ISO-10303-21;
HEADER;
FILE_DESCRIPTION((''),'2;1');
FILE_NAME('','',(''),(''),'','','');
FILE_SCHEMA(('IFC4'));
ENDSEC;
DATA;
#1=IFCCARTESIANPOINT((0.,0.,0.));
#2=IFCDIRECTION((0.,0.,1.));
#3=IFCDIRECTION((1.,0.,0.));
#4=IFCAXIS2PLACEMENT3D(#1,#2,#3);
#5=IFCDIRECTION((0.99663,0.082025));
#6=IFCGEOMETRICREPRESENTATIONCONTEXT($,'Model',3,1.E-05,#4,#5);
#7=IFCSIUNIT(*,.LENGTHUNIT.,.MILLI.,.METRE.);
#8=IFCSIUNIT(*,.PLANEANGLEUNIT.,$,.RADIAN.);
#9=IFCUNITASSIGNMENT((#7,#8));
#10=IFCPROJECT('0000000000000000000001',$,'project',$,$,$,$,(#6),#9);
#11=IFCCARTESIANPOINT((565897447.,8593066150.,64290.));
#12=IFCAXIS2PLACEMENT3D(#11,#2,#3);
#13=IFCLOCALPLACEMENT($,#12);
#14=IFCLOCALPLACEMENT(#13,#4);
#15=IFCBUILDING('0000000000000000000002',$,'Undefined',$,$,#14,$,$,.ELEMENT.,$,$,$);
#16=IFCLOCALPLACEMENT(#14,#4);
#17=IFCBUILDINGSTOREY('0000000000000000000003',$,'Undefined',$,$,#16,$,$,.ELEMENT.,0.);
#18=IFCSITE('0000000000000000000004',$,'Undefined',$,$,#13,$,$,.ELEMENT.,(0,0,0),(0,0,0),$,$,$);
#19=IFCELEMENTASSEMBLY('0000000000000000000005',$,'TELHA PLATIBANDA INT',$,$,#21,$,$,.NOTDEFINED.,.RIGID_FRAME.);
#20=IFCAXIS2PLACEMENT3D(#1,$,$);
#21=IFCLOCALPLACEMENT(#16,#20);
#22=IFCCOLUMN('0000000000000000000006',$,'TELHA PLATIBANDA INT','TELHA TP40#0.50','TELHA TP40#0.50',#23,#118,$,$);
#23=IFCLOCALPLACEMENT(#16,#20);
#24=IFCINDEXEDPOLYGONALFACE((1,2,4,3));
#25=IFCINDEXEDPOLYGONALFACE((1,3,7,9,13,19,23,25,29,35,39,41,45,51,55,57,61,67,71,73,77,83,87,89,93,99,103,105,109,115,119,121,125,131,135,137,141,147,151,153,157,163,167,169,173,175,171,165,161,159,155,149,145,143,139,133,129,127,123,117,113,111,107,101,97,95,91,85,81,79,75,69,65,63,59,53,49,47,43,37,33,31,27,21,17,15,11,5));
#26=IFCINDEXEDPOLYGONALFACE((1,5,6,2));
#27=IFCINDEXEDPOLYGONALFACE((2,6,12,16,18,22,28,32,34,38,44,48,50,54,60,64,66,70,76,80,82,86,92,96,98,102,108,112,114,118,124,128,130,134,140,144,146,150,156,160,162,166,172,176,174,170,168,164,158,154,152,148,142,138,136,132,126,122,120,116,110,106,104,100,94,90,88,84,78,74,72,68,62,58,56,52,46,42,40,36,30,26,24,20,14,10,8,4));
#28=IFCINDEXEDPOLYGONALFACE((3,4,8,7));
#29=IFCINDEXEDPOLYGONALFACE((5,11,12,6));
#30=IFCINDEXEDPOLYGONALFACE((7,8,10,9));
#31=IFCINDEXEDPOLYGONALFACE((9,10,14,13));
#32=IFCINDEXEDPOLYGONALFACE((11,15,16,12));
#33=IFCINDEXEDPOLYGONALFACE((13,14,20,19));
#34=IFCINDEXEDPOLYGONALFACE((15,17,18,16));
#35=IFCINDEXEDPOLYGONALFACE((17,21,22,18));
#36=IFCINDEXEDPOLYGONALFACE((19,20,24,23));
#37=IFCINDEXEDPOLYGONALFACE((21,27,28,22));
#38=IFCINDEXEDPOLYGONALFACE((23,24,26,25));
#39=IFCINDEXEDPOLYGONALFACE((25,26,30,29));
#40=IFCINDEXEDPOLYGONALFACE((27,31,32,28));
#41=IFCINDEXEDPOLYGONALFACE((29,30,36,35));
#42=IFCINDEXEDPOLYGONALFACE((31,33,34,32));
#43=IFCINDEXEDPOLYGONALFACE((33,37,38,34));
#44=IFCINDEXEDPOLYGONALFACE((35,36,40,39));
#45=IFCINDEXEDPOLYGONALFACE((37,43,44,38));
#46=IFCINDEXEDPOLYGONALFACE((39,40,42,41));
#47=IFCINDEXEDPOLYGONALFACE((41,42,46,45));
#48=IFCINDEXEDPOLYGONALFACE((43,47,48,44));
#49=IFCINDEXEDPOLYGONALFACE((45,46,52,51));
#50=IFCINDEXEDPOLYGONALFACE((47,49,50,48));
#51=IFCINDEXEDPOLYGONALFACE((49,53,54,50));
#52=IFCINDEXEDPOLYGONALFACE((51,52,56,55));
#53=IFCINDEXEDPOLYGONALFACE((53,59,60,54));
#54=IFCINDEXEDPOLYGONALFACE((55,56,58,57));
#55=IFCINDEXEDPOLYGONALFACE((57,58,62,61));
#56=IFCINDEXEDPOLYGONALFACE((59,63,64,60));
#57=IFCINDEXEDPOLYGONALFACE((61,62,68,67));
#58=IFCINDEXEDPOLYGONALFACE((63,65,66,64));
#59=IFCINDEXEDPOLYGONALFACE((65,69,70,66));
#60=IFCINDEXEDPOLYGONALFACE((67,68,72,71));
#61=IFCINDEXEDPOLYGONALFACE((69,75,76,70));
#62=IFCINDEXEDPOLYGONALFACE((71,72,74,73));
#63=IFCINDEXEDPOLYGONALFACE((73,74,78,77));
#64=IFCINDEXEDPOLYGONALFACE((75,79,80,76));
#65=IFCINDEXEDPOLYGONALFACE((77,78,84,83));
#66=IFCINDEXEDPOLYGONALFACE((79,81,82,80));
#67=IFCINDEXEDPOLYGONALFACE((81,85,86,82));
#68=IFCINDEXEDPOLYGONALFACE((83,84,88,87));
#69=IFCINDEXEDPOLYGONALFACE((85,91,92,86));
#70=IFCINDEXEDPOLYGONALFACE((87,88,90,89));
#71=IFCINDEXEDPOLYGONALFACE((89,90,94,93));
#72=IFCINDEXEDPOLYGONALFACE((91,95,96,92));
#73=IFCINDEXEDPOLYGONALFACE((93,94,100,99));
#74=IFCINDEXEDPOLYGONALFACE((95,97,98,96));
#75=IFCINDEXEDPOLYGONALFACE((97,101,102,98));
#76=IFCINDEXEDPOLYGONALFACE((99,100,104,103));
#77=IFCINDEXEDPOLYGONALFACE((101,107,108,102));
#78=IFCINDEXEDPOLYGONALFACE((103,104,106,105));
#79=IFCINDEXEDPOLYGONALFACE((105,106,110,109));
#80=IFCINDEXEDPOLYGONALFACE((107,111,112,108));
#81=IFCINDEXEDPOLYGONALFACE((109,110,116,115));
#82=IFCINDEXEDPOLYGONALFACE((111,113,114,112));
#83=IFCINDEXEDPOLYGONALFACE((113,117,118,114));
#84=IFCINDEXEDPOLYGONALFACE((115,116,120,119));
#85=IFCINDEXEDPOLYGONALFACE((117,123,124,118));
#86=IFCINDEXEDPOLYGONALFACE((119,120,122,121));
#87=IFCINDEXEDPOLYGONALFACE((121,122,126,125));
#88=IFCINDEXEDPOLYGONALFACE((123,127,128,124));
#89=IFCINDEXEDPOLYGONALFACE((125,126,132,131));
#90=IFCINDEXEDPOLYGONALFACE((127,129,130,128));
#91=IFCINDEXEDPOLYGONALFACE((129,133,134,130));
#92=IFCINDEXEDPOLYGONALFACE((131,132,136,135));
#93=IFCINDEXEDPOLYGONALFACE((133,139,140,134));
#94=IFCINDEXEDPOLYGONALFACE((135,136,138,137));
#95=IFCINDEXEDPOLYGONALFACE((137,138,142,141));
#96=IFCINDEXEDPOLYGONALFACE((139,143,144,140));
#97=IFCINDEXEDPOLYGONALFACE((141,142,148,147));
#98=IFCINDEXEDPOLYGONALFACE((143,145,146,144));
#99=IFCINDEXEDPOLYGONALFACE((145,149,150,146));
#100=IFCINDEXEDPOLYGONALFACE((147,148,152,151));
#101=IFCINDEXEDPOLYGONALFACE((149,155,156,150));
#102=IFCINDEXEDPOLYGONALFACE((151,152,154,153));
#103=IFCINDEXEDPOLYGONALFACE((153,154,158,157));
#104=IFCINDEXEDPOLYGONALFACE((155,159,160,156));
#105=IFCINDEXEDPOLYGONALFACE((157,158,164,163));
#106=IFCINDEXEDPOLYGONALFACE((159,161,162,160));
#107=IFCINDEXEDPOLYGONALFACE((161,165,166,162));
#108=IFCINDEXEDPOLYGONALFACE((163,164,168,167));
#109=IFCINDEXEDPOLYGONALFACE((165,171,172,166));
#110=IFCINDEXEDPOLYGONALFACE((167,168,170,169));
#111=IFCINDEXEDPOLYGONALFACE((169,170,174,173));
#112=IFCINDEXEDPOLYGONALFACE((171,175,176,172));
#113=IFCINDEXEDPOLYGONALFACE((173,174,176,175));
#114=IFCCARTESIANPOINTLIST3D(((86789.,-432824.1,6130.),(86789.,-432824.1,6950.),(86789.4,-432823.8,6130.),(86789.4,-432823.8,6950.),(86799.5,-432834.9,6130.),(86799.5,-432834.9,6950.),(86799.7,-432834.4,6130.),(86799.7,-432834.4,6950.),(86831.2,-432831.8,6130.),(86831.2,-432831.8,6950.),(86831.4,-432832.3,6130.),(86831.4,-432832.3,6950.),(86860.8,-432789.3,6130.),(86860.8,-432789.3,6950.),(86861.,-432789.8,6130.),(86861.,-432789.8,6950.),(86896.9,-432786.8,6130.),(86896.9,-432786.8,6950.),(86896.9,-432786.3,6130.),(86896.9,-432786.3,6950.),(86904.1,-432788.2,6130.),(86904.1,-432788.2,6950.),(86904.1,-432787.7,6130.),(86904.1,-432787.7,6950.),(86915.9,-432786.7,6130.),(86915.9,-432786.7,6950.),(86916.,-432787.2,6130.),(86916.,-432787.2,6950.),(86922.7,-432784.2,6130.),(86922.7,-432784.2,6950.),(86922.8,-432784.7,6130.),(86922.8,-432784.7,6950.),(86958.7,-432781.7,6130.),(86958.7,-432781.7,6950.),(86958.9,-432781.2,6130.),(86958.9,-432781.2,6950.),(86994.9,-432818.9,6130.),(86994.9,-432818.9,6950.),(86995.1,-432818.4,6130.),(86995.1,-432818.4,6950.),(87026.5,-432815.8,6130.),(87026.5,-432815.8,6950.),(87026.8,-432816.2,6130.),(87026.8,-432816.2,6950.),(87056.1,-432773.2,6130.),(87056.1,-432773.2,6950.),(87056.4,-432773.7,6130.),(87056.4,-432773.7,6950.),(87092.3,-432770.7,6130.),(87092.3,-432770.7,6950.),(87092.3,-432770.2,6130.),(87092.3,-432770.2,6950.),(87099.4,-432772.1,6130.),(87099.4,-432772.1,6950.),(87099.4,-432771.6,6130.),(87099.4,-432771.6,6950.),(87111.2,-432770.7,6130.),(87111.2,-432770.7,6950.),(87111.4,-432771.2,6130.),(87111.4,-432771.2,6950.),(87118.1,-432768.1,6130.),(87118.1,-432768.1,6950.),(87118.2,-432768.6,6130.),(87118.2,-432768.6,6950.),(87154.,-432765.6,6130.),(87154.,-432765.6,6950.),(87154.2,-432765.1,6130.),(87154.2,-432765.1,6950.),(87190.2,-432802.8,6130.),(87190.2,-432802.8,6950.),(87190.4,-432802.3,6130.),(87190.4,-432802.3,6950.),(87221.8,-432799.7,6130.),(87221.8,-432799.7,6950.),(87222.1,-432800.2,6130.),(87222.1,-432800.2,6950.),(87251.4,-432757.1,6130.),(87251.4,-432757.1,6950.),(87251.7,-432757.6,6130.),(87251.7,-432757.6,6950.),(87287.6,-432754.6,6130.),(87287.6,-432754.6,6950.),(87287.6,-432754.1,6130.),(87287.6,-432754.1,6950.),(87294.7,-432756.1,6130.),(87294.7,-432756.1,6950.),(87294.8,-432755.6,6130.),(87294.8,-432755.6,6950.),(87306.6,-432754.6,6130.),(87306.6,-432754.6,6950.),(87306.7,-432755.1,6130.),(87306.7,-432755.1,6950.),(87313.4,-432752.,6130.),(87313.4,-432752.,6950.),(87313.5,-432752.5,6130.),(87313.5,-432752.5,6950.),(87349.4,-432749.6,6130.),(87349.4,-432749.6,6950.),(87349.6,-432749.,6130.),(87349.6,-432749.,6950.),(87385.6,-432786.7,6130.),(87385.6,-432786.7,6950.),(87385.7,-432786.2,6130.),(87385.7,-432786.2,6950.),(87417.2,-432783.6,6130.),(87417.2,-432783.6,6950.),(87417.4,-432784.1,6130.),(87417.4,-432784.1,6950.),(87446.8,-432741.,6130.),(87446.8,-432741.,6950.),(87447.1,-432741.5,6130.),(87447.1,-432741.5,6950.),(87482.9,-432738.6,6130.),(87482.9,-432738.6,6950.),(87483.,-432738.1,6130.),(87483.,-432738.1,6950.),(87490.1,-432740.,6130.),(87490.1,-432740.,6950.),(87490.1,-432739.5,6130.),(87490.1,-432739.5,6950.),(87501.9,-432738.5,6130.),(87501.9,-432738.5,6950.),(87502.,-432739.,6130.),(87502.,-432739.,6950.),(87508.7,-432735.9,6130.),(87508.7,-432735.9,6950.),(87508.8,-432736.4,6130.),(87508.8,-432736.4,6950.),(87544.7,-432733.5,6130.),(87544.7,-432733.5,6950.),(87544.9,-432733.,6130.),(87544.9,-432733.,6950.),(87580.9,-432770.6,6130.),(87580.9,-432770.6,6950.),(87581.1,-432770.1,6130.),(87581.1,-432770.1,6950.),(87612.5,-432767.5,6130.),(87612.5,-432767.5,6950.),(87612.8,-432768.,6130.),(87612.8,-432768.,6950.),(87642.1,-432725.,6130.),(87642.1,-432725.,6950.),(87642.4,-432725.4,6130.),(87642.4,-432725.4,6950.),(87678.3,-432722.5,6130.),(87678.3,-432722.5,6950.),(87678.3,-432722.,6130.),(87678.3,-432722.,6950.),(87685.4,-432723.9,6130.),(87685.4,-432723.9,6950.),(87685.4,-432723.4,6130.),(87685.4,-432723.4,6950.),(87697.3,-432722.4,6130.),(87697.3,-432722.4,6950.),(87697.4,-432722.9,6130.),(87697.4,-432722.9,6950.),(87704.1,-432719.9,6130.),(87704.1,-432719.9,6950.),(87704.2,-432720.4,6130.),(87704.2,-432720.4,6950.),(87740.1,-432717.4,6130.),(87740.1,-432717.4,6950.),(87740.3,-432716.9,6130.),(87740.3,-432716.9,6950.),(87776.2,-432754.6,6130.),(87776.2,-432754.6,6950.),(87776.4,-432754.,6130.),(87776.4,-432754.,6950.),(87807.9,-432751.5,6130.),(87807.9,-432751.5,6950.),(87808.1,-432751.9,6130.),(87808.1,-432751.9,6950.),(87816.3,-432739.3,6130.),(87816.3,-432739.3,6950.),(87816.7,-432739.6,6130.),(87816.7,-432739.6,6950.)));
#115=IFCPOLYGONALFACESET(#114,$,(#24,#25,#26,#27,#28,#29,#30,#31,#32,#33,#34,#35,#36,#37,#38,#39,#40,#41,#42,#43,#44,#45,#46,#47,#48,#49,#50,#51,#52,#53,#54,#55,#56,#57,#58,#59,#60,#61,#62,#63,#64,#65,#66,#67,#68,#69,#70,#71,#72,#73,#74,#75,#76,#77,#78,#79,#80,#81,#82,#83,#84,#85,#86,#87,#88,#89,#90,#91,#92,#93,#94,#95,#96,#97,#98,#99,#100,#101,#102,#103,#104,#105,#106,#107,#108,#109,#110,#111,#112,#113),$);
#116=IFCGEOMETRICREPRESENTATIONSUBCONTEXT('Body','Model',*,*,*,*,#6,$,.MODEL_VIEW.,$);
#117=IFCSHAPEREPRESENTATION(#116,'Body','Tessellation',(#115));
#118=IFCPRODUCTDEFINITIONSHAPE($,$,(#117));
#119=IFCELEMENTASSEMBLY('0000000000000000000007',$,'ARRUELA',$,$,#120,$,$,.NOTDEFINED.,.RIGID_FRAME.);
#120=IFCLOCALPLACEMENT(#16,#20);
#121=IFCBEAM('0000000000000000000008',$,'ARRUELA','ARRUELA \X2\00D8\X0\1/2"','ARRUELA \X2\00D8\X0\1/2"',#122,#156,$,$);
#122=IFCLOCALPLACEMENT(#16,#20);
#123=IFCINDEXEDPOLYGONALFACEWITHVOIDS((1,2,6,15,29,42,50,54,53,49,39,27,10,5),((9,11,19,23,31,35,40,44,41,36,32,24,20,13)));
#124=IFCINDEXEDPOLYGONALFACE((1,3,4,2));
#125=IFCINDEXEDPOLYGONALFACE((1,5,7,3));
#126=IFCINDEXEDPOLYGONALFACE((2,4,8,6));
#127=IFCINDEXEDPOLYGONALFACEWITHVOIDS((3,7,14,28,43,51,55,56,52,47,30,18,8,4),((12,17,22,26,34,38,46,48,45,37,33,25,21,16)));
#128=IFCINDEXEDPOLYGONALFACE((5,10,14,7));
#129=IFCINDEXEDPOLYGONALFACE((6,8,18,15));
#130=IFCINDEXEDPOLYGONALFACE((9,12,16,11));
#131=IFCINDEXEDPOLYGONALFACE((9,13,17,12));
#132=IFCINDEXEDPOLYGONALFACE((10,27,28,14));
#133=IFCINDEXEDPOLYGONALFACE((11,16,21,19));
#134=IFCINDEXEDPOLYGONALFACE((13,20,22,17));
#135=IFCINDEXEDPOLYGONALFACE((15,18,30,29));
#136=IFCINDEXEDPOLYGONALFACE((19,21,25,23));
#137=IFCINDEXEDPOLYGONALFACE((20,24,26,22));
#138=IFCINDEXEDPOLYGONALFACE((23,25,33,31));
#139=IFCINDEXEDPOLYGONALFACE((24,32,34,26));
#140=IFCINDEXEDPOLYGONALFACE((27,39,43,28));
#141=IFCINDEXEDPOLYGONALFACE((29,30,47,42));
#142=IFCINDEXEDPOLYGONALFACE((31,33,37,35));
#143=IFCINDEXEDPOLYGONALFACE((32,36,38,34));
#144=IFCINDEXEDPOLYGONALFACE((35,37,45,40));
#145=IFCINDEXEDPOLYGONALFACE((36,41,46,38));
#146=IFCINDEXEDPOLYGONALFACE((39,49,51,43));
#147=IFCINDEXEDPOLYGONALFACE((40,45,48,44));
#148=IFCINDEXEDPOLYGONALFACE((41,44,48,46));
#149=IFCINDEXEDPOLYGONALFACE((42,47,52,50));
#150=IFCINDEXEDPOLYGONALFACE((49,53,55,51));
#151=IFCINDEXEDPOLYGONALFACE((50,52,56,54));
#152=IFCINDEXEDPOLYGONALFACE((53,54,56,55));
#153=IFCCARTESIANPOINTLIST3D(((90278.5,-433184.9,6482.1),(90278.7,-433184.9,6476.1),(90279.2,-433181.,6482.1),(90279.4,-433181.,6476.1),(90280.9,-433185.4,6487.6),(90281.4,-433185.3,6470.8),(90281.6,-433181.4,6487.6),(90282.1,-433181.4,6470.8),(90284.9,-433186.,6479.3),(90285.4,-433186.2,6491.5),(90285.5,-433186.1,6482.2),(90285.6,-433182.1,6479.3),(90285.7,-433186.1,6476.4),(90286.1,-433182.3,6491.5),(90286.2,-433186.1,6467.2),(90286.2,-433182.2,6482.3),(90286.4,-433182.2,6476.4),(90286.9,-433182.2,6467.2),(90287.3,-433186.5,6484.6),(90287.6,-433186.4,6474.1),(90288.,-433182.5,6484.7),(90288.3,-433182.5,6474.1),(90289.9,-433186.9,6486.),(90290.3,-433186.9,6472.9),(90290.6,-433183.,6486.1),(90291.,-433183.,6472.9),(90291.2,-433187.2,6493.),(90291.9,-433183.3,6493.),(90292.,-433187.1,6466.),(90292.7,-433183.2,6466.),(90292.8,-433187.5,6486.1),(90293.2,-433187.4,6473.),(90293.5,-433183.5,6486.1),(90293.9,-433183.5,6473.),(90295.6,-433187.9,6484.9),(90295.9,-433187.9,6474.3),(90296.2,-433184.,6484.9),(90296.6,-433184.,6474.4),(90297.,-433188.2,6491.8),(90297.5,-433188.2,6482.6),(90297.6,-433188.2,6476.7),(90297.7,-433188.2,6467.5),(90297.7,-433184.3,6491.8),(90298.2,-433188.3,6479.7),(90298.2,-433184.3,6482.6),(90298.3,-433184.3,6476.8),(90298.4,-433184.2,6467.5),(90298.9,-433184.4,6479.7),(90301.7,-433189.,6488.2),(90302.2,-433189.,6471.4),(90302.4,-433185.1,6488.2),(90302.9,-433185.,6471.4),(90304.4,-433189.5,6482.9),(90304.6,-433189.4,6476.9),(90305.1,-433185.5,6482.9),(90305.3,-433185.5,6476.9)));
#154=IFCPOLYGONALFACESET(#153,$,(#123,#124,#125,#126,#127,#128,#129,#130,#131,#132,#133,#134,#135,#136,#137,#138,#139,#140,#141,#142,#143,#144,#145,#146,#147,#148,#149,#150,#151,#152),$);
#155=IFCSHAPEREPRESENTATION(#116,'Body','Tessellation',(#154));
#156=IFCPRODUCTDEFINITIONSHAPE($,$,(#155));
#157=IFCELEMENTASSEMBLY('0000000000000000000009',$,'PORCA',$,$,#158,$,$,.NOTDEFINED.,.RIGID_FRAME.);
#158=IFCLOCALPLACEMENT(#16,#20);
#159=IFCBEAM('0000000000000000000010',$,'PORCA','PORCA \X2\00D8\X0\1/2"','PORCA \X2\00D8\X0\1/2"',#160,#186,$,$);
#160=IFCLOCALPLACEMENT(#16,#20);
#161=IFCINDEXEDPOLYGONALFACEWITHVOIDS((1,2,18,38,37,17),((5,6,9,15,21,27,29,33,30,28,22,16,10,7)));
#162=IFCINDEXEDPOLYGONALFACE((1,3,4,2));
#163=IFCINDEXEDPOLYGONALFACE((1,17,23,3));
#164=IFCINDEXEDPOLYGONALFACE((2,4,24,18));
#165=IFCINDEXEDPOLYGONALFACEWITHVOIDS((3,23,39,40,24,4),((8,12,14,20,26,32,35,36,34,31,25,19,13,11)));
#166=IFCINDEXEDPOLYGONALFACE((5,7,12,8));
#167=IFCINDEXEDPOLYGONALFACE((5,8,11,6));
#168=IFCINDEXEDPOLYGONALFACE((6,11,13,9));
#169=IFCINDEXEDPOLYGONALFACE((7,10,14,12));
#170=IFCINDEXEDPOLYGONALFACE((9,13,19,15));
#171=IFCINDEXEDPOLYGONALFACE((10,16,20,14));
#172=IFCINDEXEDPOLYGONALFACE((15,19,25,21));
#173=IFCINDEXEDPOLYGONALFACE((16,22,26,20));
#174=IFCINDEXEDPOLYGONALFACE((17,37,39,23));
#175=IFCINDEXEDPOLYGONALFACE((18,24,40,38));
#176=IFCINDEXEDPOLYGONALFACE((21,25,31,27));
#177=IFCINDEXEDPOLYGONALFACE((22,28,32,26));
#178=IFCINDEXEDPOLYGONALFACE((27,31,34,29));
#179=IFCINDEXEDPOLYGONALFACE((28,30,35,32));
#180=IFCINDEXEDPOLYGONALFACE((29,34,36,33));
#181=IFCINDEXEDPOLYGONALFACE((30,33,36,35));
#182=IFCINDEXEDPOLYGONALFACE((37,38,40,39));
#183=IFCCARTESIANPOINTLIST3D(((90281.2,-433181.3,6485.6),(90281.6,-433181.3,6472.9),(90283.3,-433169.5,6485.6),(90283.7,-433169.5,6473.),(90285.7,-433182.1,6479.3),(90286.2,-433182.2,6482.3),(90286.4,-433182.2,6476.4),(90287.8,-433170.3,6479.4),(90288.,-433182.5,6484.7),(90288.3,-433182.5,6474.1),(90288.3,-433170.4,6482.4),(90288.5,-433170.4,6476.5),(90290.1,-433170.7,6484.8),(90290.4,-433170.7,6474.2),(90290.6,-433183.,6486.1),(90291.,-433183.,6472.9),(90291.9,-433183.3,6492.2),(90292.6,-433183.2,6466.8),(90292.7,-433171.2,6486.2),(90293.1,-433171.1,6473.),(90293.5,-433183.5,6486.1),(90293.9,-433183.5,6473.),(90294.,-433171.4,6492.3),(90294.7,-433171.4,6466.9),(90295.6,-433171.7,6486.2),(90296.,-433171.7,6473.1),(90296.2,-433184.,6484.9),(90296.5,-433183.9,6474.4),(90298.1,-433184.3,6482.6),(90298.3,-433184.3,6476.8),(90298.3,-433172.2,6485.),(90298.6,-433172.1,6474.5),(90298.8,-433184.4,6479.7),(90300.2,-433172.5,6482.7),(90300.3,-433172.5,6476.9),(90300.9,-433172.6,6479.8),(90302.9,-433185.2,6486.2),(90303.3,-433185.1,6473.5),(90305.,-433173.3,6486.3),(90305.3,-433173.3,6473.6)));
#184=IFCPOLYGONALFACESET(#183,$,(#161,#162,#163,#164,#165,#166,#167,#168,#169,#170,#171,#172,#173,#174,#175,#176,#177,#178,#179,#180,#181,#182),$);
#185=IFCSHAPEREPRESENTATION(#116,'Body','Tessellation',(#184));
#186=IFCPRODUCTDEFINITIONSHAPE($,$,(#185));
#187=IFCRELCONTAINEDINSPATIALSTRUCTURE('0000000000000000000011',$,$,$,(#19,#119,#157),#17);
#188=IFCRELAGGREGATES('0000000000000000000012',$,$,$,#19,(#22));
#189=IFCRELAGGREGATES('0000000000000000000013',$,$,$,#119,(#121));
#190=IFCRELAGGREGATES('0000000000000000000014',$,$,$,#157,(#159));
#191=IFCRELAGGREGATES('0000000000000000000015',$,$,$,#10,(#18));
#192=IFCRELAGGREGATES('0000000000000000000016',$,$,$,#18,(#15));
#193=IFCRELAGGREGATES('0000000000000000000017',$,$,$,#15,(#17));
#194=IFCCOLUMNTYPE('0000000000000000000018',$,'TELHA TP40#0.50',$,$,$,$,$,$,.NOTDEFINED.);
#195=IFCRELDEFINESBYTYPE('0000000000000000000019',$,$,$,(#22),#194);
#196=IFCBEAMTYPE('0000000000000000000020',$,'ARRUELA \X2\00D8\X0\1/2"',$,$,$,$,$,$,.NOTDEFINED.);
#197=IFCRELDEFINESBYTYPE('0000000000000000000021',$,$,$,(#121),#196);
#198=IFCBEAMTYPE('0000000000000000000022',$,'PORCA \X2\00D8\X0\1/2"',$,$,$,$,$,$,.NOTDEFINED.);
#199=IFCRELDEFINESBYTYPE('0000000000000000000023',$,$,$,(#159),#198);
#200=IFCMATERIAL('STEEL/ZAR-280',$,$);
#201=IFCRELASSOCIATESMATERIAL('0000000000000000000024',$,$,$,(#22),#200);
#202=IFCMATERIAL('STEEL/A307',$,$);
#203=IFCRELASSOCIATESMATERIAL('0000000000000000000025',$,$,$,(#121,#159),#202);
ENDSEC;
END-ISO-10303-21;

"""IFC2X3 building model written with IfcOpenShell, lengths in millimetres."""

from ifc_helpers import new_model, si_unit, direction, frame, origin_with_axes, place, context, subcontext, project, spatial, polyline, outline, extrude, material, type_object, element, aggregate, save


model = new_model("IFC2X3")

# Units and contexts
model_context = context("Model", 3, precision=1e-05, world=origin_with_axes(), true_north=direction((0.99663, 0.082025)))
body_context = subcontext(model_context, "Body", "Model", "MODEL_VIEW")
ifc_project = project(units=[si_unit("LENGTHUNIT", "METRE", prefix="MILLI"), si_unit("PLANEANGLEUNIT", "RADIAN")], contexts=[model_context])

# Site, building, storey
site_placement = place(None, frame((565897447.0, 8593066150.0, 64290.0), z_axis=(0.0, 0.0, 1.0), x_axis=(1.0, 0.0, 0.0)))
site = spatial("IfcSite", under=ifc_project, at=site_placement, Name="Undefined", CompositionType="ELEMENT", RefLatitude=(0, 0, 0), RefLongitude=(0, 0, 0))
building_placement = place(site_placement, origin_with_axes())
building = spatial("IfcBuilding", under=site, at=building_placement, Name="Undefined", CompositionType="ELEMENT")
storey_placement = place(building_placement, origin_with_axes())
storey = spatial("IfcBuildingStorey", under=building, at=storey_placement, Name="Undefined", CompositionType="ELEMENT", Elevation=0.0)

# Element assembly, column
ifc_material_1 = material(Name="STEEL/ZAR-280")
column_type = type_object("IfcColumnType", Name="TELHA TP40#0.50", PredefinedType="NOTDEFINED")
assembly_1_placement = place(storey_placement, origin_with_axes())
assembly_1 = element("IfcElementAssembly", 1, at=assembly_1_placement, inside=storey, Name="TELHA PLATIBANDA INT", AssemblyPlace="NOTDEFINED", PredefinedType="RIGID_FRAME")
column_1_placement = place(assembly_1_placement, frame((87302.4, -432773.2, 6130.0), z_axis=(0.0, 0.0, 1.0), x_axis=(0.082025, -0.99663, 0.0)))
column_1 = element("IfcColumn", 2, at=column_1_placement, type_object=column_type, material=ifc_material_1, Name="TELHA PLATIBANDA INT", Description="TELHA TP40#0.50", ObjectType="TELHA TP40#0.50", context=body_context, shape_type="SweptSolid", body=[
    extrude(outline(polyline([(440.8, -19.8), (473.8, 20.2), (505.8, 20.2), (515.4, 8.6), (515.0, 8.3), (505.6, 19.8), (474.0, 19.8), (441.0, -20.2), (404.7, -20.2), (397.7, -18.2), (385.9, -18.2), (378.9, -20.2), (342.6, -20.2), (309.6, 19.8), (278.0, 19.8), (245.0, -20.2), (208.7, -20.2), (201.7, -18.2), (189.9, -18.2), (182.9, -20.2), (146.6, -20.2), (113.6, 19.8), (82.0, 19.8), (49.0, -20.2), (12.7, -20.2), (5.7, -18.2), (-6.1, -18.2), (-13.1, -20.2), (-49.4, -20.2), (-82.4, 19.8), (-114.0, 19.8), (-147.0, -20.2), (-183.3, -20.2), (-190.3, -18.2), (-202.1, -18.2), (-209.1, -20.2), (-245.4, -20.2), (-278.4, 19.8), (-310.0, 19.8), (-343.0, -20.2), (-379.3, -20.2), (-386.3, -18.2), (-398.1, -18.2), (-405.1, -20.2), (-441.4, -20.2), (-474.4, 19.8), (-506.0, 19.8), (-515.4, 8.3), (-515.8, 8.6), (-506.2, 20.2), (-474.2, 20.2), (-441.2, -19.8), (-405.2, -19.8), (-398.2, -17.8), (-386.2, -17.8), (-379.2, -19.8), (-343.2, -19.8), (-310.2, 20.2), (-278.2, 20.2), (-245.2, -19.8), (-209.2, -19.8), (-202.2, -17.8), (-190.2, -17.8), (-183.2, -19.8), (-147.2, -19.8), (-114.2, 20.2), (-82.2, 20.2), (-49.2, -19.8), (-13.2, -19.8), (-6.2, -17.8), (5.8, -17.8), (12.8, -19.8), (48.8, -19.8), (81.8, 20.2), (113.8, 20.2), (146.8, -19.8), (182.8, -19.8), (189.8, -17.8), (201.8, -17.8), (208.8, -19.8), (244.8, -19.8), (277.8, 20.2), (309.8, 20.2), (342.8, -19.8), (378.8, -19.8), (385.8, -17.8), (397.8, -17.8), (404.8, -19.8), (440.8, -19.8)])), frame((0.0, 0.0, 820.0), z_axis=(0.0, 0.0, -1.0), x_axis=(0.0, 1.0, 0.0)), (0.0, 0.0, 1.0), 820.0),
])
aggregate(assembly_1, [column_1])

# Element assemblies, beams
assembly_2_placement = place(storey_placement, origin_with_axes())
assembly_2 = element("IfcElementAssembly", 3, at=assembly_2_placement, inside=storey, Name="ARRUELA", AssemblyPlace="NOTDEFINED", PredefinedType="RIGID_FRAME")
ifc_material_2 = material(Name="STEEL/A307")
beam_type_1 = type_object("IfcBeamType", Name="ARRUELA Ø1/2\"", PredefinedType="NOTDEFINED")
beam_1_placement = place(assembly_2_placement, frame((90292.3, -433183.2, 6479.5), z_axis=(0.984501, -0.172962, 0.02901), x_axis=(-0.172812, -0.984925, -0.007591)))
beam_1 = element("IfcBeam", 4, at=beam_1_placement, type_object=beam_type_1, material=ifc_material_2, Name="ARRUELA", Description="ARRUELA Ø1/2\"", ObjectType="ARRUELA Ø1/2\"", context=body_context, shape_type="SweptSolid", body=[
    extrude(outline(polyline([(-8.4, 10.5), (-3.0, 13.2), (3.0, 13.2), (8.4, 10.5), (12.2, 5.9), (13.5, 0.0), (12.2, -5.9), (8.4, -10.5), (3.0, -13.2), (-3.0, -13.2), (-8.4, -10.5), (-12.2, -5.9), (-13.5, 0.0), (-12.2, 5.9), (-8.4, 10.5)]), holes=[polyline([(6.6, 1.5), (5.3, 4.2), (2.9, 6.1), (0.0, 6.7), (-2.9, 6.1), (-5.3, 4.2), (-6.6, 1.5), (-6.6, -1.5), (-5.3, -4.2), (-2.9, -6.1), (0.0, -6.8), (2.9, -6.1), (5.3, -4.2), (6.6, -1.5), (6.6, 1.5)])]), frame((4.0, 0.0, 0.0), z_axis=(-1.0, 0.0, 0.0), x_axis=(0.0, -1.0, 0.0)), (0.0, 0.0, 1.0), 4.0),
])
aggregate(assembly_2, [beam_1])
assembly_3_placement = place(storey_placement, origin_with_axes())
assembly_3 = element("IfcElementAssembly", 5, at=assembly_3_placement, inside=storey, Name="PORCA", AssemblyPlace="NOTDEFINED", PredefinedType="RIGID_FRAME")
beam_type_2 = type_object("IfcBeamType", Name="PORCA Ø1/2\"", PredefinedType="NOTDEFINED")
beam_2_placement = place(assembly_3_placement, frame((90294.3, -433171.4, 6479.6), z_axis=(0.984501, -0.172962, 0.02901), x_axis=(-0.172812, -0.984925, -0.007591)))
beam_2 = element("IfcBeam", 6, at=beam_2_placement, type_object=beam_type_2, material=ifc_material_2, Name="PORCA", Description="PORCA Ø1/2\"", ObjectType="PORCA Ø1/2\"", context=body_context, shape_type="SweptSolid", body=[
    extrude(outline(polyline([(12.7, 0.0), (6.3, -11.0), (-6.3, -11.0), (-12.7, 0.0), (-6.3, 11.0), (6.3, 11.0), (12.7, 0.0)]), holes=[polyline([(-5.3, -4.2), (-2.9, -6.0), (0.0, -6.7), (2.9, -6.0), (5.3, -4.2), (6.6, -1.5), (6.6, 1.5), (5.3, 4.2), (2.9, 6.0), (0.0, 6.7), (-2.9, 6.0), (-5.3, 4.2), (-6.6, 1.5), (-6.6, -1.5), (-5.3, -4.2)])]), frame((12.0, 0.0, 0.0), z_axis=(-1.0, 0.0, 0.0), x_axis=(0.0, -1.0, 0.0)), (0.0, 0.0, 1.0), 12.0),
])
aggregate(assembly_3, [beam_2])

save(model, "model.ifc")
